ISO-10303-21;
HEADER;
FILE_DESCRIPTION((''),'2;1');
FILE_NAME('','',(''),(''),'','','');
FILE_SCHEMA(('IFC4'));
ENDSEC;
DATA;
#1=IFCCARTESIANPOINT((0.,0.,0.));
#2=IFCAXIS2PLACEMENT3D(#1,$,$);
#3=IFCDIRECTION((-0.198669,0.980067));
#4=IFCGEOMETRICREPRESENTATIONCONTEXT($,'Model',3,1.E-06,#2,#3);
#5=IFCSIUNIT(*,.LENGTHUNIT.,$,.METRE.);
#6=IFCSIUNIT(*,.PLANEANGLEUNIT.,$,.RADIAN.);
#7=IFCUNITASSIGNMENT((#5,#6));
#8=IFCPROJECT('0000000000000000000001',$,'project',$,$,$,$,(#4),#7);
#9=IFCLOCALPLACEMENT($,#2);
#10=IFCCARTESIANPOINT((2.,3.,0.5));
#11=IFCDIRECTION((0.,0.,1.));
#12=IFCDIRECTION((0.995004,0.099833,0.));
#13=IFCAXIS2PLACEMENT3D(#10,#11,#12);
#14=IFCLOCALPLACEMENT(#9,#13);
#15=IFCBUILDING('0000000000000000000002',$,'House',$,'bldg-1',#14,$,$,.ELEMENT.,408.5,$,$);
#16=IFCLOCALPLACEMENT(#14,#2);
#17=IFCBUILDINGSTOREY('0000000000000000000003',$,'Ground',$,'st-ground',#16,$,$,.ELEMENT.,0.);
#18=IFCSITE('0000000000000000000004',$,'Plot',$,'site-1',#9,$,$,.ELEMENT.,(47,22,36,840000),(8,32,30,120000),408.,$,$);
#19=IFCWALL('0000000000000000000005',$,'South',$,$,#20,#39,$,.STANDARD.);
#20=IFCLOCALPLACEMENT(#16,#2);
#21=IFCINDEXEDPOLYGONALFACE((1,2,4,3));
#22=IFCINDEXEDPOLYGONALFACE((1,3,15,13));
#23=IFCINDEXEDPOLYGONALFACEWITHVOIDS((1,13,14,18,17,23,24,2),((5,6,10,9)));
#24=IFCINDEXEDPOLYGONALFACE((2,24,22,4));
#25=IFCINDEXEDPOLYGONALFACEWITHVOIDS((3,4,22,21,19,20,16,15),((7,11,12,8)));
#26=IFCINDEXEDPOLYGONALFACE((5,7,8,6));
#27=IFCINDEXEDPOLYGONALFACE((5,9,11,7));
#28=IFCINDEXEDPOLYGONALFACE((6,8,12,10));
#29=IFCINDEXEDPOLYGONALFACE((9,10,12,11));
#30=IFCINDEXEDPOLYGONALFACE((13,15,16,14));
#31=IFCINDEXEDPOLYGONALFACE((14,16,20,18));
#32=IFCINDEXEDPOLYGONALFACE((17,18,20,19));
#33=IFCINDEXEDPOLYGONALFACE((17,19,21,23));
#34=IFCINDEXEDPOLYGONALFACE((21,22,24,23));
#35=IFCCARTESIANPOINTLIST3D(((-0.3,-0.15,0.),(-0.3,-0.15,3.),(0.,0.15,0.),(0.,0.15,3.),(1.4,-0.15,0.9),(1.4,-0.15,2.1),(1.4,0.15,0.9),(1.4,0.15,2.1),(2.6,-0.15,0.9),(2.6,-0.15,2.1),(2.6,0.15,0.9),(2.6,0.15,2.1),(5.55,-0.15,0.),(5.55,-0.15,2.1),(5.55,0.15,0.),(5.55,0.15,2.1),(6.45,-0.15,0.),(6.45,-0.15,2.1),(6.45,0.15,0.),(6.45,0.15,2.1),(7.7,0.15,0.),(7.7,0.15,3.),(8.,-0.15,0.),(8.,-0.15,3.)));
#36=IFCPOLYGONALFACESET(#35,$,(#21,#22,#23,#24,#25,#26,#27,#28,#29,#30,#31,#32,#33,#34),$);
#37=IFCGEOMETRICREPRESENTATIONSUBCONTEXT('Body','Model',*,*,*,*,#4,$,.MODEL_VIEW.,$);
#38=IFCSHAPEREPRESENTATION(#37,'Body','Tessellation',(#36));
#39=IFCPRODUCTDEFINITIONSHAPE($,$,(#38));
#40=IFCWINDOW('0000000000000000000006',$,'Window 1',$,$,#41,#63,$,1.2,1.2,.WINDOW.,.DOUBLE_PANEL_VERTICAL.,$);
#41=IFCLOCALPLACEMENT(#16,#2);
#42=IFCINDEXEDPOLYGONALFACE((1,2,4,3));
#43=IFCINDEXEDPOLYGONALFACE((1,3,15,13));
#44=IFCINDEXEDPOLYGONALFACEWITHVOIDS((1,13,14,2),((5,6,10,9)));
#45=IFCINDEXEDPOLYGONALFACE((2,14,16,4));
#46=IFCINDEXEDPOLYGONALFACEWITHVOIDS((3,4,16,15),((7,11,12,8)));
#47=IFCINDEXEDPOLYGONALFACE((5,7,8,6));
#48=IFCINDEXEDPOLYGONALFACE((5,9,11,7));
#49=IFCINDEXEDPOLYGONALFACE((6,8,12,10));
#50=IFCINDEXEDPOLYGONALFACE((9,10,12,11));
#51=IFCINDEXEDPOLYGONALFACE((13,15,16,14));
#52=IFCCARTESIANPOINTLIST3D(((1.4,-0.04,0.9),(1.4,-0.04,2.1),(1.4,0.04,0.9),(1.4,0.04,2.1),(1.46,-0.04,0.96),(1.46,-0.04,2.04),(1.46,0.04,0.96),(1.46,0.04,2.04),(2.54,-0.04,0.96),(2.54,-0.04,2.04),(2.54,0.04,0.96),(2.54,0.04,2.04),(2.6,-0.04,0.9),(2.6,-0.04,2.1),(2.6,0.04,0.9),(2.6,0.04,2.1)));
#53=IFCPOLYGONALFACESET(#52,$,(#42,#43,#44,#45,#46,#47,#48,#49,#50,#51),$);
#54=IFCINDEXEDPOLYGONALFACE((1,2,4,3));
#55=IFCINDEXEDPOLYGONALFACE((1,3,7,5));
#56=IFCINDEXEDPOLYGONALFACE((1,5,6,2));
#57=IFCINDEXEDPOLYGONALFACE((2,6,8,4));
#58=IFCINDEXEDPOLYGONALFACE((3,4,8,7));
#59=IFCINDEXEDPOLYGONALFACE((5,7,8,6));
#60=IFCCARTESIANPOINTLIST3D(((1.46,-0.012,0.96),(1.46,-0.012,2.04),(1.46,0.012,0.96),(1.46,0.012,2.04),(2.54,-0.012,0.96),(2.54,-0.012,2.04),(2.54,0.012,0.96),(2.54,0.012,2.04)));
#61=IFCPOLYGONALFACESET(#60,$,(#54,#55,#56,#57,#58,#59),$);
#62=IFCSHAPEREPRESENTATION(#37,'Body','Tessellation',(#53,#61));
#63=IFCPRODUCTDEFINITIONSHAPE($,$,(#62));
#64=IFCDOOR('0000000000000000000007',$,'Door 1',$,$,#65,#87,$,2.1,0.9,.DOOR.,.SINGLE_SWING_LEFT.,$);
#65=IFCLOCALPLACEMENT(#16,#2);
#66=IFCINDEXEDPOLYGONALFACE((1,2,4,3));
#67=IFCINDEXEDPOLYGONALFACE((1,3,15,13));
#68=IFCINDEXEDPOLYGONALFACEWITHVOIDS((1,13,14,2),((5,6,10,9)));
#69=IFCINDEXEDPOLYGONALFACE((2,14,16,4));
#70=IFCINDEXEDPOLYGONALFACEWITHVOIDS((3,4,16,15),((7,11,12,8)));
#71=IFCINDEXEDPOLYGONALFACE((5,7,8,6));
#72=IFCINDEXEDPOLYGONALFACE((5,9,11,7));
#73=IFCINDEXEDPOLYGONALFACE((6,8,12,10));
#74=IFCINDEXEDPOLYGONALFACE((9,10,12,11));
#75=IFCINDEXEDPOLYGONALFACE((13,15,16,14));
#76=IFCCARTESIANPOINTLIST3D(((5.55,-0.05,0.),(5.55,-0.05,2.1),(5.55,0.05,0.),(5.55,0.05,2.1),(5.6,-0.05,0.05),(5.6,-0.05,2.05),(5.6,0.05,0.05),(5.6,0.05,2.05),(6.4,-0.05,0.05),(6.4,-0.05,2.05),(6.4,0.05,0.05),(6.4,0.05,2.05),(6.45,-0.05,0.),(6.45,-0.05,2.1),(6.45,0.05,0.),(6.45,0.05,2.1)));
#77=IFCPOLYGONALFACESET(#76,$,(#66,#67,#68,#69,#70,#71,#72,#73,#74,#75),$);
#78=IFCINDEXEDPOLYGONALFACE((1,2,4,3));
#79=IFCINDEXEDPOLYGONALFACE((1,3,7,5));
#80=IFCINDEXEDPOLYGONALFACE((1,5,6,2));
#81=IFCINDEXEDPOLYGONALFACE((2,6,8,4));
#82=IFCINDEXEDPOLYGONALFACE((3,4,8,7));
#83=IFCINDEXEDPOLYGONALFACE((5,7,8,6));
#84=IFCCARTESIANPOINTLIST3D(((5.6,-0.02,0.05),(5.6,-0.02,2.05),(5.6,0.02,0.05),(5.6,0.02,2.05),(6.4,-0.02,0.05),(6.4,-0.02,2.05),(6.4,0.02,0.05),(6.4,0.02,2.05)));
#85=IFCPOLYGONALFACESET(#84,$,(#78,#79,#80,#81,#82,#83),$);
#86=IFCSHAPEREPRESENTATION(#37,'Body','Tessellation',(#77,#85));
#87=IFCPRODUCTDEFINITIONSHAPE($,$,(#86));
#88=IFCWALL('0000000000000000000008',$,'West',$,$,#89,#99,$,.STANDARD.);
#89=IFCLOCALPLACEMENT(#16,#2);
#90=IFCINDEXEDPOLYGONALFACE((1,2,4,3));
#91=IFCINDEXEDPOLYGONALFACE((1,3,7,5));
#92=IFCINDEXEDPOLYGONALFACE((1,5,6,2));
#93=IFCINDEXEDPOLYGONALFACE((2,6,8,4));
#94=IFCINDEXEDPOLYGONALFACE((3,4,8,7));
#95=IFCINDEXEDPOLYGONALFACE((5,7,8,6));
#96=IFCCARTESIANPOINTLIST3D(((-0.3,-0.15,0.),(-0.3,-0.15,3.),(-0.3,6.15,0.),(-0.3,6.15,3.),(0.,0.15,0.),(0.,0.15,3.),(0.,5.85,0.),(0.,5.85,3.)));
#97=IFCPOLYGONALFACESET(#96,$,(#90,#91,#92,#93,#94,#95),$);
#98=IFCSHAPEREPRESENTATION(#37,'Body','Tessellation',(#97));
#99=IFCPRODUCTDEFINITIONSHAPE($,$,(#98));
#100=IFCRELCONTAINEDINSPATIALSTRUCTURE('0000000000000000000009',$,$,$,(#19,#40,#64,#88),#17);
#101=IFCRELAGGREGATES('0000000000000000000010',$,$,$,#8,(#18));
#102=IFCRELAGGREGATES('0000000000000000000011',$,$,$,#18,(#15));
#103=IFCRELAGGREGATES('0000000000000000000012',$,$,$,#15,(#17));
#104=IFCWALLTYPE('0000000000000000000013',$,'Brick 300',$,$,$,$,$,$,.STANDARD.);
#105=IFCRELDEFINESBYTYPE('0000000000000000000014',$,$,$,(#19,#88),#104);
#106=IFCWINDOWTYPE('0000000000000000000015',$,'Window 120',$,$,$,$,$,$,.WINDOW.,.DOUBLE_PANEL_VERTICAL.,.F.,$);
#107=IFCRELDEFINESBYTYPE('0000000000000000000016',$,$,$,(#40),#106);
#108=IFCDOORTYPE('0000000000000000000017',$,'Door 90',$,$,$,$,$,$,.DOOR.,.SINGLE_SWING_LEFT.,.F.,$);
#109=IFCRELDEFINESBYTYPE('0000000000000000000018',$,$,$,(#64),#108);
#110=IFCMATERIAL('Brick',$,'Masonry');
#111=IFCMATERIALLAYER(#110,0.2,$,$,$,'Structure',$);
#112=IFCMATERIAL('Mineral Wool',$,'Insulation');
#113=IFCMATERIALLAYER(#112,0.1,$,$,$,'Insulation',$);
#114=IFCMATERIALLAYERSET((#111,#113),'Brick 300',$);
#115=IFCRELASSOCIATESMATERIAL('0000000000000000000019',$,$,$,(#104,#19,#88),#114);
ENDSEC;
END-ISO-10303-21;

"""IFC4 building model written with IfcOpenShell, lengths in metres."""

from ifc_helpers import new_model, si_unit, direction, frame, frame_2d, origin, origin_2d, place, context, subcontext, project, spatial, polyline, rectangle, outline, extrude, material, layer, layer_set, layer_usage, type_object, element, fill, save


model = new_model("IFC4")

# Units and contexts
model_context = context("Model", 3, precision=1e-06, world=origin(), true_north=direction((-0.198669, 0.980067)))
body_context = subcontext(model_context, "Body", "Model", "MODEL_VIEW")
ifc_project = project(units=[si_unit("LENGTHUNIT", "METRE"), si_unit("PLANEANGLEUNIT", "RADIAN")], contexts=[model_context])

# Site, building, storey
site_placement = place(None, origin())
site = spatial("IfcSite", under=ifc_project, at=site_placement, Name="Plot", ObjectType="site-1", CompositionType="ELEMENT", RefLatitude=(47, 22, 36, 840000), RefLongitude=(8, 32, 30, 120000), RefElevation=408.0)
building_placement = place(site_placement, frame((2.0, 3.0, 0.5), z_axis=(0.0, 0.0, 1.0), x_axis=(0.995004, 0.099833, 0.0)))
building = spatial("IfcBuilding", under=site, at=building_placement, Name="House", ObjectType="bldg-1", CompositionType="ELEMENT", ElevationOfRefHeight=408.5)
storey_placement = place(building_placement, origin())
storey = spatial("IfcBuildingStorey", under=building, at=storey_placement, Name="Ground", ObjectType="st-ground", CompositionType="ELEMENT", Elevation=0.0)

# Shared definitions
window_type = type_object("IfcWindowType", Name="Window 120", ParameterTakesPrecedence=False, PartitioningType="DOUBLE_PANEL_VERTICAL", PredefinedType="WINDOW")

# Shared definitions
ifc_material_1 = material(Name="Brick", Category="Masonry")
ifc_layer_1 = layer(ifc_material_1, 0.2, Category="Structure")
ifc_material_2 = material(Name="Mineral Wool", Category="Insulation")
ifc_layer_2 = layer(ifc_material_2, 0.1, Category="Insulation")
ifc_layer_set_1 = layer_set([ifc_layer_1, ifc_layer_2], Name="Brick 300")
wall_type_1 = type_object("IfcWallType", Name="Brick 300", PredefinedType="STANDARD", material=ifc_layer_set_1)

# Wall, openings, window, door
ifc_layer_usage_1 = layer_usage(ifc_layer_set_1, "AXIS2", "NEGATIVE", 0.15)
wall_1_placement = place(storey_placement, origin())
wall_1 = element("IfcWall", 1, at=wall_1_placement, inside=storey, type_object=wall_type_1, material=ifc_layer_usage_1, Name="South", PredefinedType="STANDARD", context=body_context, shape_type="SweptSolid", body=[
    extrude(outline(polyline([(-0.3, -0.15), (8.0, -0.15), (7.7, 0.15), (0.0, 0.15), (-0.3, -0.15)])), origin(), (0.0, 0.0, 1.0), 3.0),
])
opening_1_placement = place(wall_1_placement, frame((6.0, 0.0, 0.0), z_axis=(0.0, 0.0, 1.0), x_axis=(1.0, 0.0, 0.0)))
opening_1 = element("IfcOpeningElement", 2, at=opening_1_placement, cuts=wall_1, PredefinedType="OPENING", context=body_context, shape_type="SweptSolid", body=[
    extrude(rectangle(XDim=0.9, YDim=0.3, at=origin_2d()), origin(), (0.0, 0.0, 1.0), 2.1),
])
opening_2_placement = place(wall_1_placement, frame((2.0, 0.0, 0.9), z_axis=(0.0, 0.0, 1.0), x_axis=(1.0, 0.0, 0.0)))
opening_2 = element("IfcOpeningElement", 3, at=opening_2_placement, cuts=wall_1, PredefinedType="OPENING", context=body_context, shape_type="SweptSolid", body=[
    extrude(rectangle(XDim=1.2, YDim=0.3, at=origin_2d()), origin(), (0.0, 0.0, 1.0), 1.2),
])
window_1_placement = place(opening_2_placement, frame((0.0, 0.0, 0.0), z_axis=(0.0, -1.0, 0.0), x_axis=(1.0, 0.0, 0.0)))
window_1 = element("IfcWindow", 4, at=window_1_placement, inside=storey, type_object=window_type, Name="Window 1", OverallHeight=1.2, OverallWidth=1.2, PartitioningType="DOUBLE_PANEL_VERTICAL", PredefinedType="WINDOW", context=body_context, shape_type="SweptSolid", body=[
    extrude(outline(polyline([(-0.6, 0.0), (0.6, 0.0), (0.6, 1.2), (-0.6, 1.2), (-0.6, 0.0)]), holes=[polyline([(-0.54, 0.06), (0.54, 0.06), (0.54, 1.14), (-0.54, 1.14), (-0.54, 0.06)])]), frame((0.0, 0.0, -0.04)), (0.0, 0.0, 1.0), 0.08),
    extrude(rectangle(XDim=1.08, YDim=1.08, at=frame_2d((0.0, 0.6))), frame((0.0, 0.0, -0.012)), (0.0, 0.0, 1.0), 0.024),
])
fill(opening_2, window_1)
door_type = type_object("IfcDoorType", Name="Door 90", OperationType="SINGLE_SWING_LEFT", ParameterTakesPrecedence=False, PredefinedType="DOOR")
door_placement = place(opening_1_placement, frame((0.0, 0.0, 0.0), z_axis=(0.0, -1.0, 0.0), x_axis=(1.0, 0.0, 0.0)))
door = element("IfcDoor", 5, at=door_placement, inside=storey, type_object=door_type, Name="Door 1", OperationType="SINGLE_SWING_LEFT", OverallHeight=2.1, OverallWidth=0.9, PredefinedType="DOOR", context=body_context, shape_type="SweptSolid", body=[
    extrude(outline(polyline([(-0.45, 0.0), (0.45, 0.0), (0.45, 2.1), (-0.45, 2.1), (-0.45, 0.0)]), holes=[polyline([(-0.4, 0.05), (0.4, 0.05), (0.4, 2.05), (-0.4, 2.05), (-0.4, 0.05)])]), frame((0.0, 0.0, -0.05)), (0.0, 0.0, 1.0), 0.1),
    extrude(rectangle(XDim=0.8, YDim=2.0, at=frame_2d((0.0, 1.05))), frame((0.0, 0.0, -0.02)), (0.0, 0.0, 1.0), 0.04),
])
fill(opening_1, door)

# Wall
ifc_layer_usage_2 = layer_usage(ifc_layer_set_1, "AXIS2", "NEGATIVE", 0.0)
wall_2_placement = place(storey_placement, origin())
element("IfcWall", 6, at=wall_2_placement, inside=storey, type_object=wall_type_1, material=ifc_layer_usage_2, Name="West", PredefinedType="STANDARD", context=body_context, shape_type="SweptSolid", body=[
    extrude(outline(polyline([(-0.3, 6.15), (-0.3, -0.15), (0.0, 0.15), (0.0, 5.85), (-0.3, 6.15)])), origin(), (0.0, 0.0, 1.0), 3.0),
])

save(model, "model.ifc")
